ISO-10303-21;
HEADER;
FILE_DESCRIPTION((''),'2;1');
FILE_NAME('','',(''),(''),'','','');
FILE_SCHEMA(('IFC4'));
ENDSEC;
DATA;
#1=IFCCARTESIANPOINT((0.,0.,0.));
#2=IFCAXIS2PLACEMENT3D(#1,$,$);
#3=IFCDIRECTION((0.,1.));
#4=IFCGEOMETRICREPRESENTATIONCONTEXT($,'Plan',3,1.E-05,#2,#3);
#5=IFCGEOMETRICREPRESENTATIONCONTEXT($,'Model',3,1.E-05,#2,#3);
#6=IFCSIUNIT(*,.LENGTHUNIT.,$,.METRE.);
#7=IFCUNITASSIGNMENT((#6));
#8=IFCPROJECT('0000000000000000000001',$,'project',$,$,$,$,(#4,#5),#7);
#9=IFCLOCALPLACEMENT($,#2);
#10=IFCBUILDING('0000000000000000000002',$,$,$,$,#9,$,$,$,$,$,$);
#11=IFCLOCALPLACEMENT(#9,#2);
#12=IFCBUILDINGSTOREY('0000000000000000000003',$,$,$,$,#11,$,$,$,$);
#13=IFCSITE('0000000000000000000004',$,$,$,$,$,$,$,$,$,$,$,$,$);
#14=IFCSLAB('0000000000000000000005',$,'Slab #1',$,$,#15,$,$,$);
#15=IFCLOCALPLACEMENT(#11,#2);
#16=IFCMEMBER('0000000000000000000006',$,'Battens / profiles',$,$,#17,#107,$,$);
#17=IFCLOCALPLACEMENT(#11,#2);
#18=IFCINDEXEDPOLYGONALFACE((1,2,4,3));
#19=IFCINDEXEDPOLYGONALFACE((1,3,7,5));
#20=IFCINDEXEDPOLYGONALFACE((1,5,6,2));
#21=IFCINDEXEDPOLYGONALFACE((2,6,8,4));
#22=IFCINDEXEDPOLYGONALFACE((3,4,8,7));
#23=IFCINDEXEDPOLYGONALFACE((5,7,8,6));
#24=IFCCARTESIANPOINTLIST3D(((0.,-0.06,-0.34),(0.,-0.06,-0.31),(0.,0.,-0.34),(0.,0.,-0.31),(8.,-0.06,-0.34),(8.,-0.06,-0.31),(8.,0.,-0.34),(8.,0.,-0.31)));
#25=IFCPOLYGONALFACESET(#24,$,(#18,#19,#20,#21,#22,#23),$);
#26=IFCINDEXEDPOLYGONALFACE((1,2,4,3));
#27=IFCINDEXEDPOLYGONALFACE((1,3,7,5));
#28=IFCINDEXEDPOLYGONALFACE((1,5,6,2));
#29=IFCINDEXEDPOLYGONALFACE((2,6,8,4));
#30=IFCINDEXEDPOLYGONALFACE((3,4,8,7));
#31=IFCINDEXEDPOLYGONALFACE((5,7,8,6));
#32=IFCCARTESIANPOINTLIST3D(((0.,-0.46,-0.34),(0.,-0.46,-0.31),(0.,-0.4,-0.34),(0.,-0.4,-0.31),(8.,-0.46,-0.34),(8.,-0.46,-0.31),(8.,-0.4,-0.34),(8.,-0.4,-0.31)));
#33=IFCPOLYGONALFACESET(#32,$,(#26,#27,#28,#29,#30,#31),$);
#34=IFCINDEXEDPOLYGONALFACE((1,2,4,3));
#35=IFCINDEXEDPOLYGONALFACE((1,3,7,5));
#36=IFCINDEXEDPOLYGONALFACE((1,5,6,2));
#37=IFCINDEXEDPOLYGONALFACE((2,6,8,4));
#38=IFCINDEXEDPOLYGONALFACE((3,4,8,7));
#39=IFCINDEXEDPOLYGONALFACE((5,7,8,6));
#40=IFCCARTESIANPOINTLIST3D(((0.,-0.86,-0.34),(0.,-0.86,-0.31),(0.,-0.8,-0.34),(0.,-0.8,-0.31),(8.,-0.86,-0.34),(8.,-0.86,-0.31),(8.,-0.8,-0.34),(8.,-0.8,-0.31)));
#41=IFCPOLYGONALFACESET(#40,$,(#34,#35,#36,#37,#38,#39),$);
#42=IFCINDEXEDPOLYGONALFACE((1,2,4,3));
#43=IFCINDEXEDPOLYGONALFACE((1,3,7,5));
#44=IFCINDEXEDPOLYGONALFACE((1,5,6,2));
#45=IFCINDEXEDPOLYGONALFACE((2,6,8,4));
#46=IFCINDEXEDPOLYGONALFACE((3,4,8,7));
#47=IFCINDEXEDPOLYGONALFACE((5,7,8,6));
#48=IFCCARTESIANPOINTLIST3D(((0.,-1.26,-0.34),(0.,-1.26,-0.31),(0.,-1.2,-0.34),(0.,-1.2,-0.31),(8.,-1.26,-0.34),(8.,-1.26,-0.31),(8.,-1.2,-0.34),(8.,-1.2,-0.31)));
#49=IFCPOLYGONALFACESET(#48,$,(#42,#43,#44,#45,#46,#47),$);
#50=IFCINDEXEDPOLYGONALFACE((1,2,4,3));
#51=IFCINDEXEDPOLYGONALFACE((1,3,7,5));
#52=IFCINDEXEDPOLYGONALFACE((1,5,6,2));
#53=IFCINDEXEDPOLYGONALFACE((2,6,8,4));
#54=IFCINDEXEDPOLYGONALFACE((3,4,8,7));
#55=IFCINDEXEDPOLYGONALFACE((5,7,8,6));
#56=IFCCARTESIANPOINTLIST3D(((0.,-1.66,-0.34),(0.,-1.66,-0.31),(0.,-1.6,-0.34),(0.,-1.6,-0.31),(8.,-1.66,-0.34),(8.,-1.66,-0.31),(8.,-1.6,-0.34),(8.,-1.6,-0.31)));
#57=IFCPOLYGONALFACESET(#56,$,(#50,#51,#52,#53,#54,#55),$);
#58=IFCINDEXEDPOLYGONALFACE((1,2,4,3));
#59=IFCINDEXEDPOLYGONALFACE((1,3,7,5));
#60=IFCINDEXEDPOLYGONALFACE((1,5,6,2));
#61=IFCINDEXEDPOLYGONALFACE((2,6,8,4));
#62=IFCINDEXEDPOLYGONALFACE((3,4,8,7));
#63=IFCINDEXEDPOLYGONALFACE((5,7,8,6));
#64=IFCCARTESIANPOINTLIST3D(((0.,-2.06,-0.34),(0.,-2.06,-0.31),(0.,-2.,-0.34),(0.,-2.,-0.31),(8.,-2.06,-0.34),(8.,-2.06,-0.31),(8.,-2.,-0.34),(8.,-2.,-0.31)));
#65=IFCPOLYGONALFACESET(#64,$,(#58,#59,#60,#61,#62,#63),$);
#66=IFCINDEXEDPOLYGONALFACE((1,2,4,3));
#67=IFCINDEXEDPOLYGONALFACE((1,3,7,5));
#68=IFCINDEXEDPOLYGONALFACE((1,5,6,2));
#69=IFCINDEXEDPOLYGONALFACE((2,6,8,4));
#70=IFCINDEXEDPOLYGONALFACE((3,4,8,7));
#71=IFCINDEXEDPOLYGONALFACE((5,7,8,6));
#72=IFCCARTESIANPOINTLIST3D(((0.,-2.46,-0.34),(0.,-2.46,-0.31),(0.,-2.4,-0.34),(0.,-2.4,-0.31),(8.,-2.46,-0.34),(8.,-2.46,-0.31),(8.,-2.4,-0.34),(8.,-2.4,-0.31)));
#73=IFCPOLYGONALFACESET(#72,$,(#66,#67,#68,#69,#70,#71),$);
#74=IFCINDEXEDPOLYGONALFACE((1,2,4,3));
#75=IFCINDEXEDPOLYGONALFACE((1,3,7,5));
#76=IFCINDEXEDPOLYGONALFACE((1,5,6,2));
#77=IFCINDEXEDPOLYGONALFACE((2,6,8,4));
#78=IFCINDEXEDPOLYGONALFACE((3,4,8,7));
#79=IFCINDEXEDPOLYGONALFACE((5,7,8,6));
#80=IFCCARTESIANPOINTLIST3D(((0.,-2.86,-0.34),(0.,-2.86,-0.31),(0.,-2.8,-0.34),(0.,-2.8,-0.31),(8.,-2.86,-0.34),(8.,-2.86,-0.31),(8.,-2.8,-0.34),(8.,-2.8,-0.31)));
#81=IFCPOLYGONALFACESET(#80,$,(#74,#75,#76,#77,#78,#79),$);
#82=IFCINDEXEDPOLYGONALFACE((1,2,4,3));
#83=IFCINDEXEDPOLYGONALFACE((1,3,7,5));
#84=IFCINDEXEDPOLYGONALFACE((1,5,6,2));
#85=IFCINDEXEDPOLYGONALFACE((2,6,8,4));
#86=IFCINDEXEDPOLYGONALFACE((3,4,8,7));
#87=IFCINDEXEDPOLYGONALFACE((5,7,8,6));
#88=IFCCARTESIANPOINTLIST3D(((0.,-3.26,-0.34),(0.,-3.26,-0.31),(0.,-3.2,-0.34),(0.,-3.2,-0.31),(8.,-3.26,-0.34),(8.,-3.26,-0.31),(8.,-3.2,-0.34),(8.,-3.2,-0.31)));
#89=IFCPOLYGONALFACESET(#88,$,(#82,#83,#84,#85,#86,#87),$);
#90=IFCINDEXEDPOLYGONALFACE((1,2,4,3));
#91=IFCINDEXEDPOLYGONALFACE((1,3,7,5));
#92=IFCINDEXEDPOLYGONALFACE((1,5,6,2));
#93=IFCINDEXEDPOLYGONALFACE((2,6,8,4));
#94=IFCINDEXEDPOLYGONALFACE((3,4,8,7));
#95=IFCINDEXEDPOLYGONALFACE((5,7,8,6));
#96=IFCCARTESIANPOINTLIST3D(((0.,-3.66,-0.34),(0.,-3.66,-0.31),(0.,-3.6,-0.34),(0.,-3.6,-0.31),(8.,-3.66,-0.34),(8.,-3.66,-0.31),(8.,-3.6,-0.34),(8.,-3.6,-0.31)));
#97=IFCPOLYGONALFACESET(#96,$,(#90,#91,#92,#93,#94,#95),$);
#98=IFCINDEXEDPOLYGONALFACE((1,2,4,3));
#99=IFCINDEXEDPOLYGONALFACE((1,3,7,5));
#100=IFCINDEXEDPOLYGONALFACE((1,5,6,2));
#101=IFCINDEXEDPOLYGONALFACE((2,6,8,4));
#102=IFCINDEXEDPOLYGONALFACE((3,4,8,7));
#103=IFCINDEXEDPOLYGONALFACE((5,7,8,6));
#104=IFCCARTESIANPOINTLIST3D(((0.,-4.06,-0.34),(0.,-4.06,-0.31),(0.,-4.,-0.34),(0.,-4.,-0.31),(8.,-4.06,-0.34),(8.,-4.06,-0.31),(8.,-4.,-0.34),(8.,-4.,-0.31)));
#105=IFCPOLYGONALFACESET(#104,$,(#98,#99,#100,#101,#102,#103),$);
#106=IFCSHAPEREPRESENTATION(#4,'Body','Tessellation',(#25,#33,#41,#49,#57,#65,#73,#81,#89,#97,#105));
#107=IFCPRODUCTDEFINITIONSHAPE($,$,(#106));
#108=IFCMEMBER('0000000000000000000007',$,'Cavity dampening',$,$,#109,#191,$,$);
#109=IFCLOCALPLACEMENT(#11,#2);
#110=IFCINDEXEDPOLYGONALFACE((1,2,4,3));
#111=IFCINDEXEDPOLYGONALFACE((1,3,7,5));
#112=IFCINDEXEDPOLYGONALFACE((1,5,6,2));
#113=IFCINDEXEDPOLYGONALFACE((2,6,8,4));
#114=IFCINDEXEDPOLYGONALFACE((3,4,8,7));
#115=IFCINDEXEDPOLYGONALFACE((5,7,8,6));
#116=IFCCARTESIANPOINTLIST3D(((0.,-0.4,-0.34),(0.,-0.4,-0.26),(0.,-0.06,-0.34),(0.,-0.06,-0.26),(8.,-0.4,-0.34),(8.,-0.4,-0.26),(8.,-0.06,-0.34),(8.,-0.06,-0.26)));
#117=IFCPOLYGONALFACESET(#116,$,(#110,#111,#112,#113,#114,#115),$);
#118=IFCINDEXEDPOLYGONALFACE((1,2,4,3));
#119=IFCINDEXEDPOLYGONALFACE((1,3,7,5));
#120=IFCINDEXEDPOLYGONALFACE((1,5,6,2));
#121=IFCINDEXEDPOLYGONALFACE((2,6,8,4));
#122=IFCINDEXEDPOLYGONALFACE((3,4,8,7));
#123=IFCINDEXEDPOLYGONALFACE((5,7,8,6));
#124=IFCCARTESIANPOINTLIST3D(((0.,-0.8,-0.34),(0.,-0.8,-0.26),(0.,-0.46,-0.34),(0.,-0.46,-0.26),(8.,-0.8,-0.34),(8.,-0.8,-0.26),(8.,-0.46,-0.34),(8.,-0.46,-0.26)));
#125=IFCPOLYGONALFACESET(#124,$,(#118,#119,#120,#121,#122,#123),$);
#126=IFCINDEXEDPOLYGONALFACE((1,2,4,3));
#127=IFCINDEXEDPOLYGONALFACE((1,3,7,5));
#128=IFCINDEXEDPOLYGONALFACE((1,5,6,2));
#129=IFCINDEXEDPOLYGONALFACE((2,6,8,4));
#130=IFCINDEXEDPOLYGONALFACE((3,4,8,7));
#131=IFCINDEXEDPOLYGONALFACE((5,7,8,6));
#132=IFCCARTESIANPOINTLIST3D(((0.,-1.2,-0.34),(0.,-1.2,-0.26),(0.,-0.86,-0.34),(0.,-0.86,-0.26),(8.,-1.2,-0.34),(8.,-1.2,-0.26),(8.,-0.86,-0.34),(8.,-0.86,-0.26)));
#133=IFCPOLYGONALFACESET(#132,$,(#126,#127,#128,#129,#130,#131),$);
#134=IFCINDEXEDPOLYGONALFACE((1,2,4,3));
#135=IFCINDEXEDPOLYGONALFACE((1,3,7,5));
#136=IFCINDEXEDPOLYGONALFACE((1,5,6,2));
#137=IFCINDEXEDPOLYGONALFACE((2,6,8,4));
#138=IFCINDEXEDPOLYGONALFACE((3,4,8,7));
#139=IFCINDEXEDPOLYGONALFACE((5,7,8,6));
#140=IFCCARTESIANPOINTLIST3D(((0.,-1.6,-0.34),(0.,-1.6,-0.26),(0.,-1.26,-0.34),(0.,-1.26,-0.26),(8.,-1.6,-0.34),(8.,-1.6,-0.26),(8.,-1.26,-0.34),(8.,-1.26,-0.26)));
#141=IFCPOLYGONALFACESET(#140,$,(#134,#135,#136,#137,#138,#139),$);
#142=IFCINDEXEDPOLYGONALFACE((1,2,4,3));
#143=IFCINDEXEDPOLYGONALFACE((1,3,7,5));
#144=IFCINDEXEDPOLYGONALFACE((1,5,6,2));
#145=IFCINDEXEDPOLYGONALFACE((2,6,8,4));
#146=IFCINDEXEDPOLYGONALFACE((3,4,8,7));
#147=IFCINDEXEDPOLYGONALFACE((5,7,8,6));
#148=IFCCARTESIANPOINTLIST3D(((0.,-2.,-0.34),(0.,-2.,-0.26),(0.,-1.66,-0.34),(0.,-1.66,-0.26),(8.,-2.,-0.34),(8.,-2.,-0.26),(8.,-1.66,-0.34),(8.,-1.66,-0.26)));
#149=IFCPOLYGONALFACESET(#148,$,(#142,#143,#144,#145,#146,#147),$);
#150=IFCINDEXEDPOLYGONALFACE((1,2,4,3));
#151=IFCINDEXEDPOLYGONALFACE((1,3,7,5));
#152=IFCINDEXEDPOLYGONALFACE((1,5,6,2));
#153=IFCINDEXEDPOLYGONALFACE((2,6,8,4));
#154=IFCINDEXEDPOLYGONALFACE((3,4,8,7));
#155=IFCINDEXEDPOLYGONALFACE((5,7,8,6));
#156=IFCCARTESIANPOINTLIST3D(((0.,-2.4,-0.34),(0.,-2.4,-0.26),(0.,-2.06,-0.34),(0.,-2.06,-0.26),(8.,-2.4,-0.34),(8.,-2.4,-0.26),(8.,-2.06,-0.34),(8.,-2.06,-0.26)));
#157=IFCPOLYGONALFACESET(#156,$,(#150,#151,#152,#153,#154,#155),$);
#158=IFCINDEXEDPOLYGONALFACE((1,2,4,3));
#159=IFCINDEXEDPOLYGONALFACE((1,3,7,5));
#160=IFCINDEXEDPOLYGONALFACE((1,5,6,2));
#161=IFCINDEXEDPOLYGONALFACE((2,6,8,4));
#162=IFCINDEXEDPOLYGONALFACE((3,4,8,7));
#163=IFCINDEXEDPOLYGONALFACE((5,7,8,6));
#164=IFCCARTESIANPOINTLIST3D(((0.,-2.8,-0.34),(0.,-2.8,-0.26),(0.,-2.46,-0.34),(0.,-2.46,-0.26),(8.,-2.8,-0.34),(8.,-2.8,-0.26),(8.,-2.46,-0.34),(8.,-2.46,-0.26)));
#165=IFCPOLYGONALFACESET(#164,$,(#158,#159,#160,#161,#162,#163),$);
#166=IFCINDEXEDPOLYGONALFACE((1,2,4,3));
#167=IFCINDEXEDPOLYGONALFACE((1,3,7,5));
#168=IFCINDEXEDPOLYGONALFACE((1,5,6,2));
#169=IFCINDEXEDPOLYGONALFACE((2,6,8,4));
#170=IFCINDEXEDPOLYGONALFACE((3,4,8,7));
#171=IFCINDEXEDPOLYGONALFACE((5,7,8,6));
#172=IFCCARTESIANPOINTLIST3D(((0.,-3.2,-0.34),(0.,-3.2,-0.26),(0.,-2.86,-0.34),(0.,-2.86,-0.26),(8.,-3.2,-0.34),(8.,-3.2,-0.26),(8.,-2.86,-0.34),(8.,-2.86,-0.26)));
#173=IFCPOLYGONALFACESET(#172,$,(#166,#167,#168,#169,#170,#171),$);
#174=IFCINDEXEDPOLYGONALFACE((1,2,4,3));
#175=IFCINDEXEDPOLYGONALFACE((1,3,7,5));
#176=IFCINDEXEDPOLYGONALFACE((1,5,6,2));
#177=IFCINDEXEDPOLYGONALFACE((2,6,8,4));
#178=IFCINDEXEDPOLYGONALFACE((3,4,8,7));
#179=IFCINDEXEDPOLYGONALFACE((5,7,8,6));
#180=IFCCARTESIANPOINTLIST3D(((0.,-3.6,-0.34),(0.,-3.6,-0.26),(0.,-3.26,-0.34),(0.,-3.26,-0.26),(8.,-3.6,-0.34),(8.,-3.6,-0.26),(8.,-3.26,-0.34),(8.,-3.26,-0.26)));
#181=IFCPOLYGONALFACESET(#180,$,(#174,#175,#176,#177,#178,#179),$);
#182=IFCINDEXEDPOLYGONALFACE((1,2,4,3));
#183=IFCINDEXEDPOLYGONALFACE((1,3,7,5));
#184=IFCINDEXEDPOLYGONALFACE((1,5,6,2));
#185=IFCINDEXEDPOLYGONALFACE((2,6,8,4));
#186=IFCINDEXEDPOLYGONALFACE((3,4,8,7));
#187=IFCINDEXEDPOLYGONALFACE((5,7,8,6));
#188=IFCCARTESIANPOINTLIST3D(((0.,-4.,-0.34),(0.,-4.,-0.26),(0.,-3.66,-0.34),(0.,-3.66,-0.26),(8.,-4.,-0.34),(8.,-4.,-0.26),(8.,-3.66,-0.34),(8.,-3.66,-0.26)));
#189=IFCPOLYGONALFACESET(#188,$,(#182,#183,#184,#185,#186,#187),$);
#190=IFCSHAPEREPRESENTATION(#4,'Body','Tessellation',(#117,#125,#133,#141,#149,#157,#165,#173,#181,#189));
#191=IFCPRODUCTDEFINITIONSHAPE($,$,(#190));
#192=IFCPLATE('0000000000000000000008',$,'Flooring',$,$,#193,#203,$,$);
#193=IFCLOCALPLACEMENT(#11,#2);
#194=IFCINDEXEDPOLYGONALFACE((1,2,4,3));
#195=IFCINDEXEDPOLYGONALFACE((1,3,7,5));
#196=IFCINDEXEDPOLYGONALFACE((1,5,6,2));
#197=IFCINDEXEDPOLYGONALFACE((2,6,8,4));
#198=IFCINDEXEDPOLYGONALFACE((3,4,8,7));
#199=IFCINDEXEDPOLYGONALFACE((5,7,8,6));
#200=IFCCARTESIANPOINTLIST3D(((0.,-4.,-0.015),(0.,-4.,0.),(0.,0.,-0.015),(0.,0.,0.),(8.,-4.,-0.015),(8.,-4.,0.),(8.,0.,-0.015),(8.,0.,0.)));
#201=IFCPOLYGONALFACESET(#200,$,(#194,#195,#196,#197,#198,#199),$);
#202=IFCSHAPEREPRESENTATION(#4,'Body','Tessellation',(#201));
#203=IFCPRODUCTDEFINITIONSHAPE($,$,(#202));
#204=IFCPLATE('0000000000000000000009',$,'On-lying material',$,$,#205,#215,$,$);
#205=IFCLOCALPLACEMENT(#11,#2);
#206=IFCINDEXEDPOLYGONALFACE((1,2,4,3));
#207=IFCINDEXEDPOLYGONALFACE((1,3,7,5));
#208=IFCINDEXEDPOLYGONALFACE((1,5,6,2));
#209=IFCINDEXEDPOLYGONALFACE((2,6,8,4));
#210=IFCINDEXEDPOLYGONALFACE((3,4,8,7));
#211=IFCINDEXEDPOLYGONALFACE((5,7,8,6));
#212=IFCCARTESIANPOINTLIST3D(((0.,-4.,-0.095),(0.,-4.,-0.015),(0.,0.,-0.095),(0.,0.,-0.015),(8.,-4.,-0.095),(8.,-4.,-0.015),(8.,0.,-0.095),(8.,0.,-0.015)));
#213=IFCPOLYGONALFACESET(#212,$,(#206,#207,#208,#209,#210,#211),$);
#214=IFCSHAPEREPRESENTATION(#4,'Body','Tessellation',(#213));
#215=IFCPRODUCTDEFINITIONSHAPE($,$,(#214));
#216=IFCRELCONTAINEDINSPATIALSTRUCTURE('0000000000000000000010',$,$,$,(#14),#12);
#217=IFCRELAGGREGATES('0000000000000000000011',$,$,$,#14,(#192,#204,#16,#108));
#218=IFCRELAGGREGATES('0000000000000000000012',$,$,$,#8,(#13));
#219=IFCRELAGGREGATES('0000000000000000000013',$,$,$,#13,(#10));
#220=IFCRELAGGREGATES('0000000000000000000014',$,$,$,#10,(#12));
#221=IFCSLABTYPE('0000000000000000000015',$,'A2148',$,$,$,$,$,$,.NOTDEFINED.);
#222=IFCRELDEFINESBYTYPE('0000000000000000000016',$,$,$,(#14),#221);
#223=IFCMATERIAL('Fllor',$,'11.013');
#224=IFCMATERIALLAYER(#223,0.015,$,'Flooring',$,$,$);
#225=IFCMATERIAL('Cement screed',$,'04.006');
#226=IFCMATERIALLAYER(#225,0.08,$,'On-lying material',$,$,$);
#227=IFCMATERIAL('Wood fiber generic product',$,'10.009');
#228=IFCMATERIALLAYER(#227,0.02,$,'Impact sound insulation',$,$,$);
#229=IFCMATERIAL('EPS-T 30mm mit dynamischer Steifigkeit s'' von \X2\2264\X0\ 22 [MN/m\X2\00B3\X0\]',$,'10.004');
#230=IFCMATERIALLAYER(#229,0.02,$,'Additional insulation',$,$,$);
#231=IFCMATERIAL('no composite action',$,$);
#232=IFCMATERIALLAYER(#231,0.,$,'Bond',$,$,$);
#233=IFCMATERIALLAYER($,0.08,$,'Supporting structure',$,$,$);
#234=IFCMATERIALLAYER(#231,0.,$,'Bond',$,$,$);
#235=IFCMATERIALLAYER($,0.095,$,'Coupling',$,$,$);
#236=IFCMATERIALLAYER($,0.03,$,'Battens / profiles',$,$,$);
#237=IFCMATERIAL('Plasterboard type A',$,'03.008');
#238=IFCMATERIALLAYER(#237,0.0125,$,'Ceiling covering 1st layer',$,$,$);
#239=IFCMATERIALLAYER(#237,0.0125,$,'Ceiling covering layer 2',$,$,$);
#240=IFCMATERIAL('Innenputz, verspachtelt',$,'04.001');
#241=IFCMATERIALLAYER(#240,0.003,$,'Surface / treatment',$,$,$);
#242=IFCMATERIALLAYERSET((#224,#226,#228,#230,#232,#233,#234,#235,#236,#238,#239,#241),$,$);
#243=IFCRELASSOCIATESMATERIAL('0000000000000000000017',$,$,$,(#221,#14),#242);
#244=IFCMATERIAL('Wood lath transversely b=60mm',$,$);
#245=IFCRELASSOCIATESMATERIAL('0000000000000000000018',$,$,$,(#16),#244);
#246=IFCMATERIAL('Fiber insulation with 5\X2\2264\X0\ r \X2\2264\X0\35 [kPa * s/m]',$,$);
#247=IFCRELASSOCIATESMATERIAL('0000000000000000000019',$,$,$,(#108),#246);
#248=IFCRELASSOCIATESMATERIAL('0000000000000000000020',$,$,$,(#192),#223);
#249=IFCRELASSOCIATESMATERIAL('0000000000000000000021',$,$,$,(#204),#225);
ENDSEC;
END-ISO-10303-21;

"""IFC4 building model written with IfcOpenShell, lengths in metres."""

from ifc_helpers import new_model, si_unit, direction, frame, frame_2d, origin, origin_with_axes, place, context, project, spatial, rectangle, extrude, material, layer, layer_set, type_object, element, aggregate, save


model = new_model("IFC4")

# Units and contexts
plan_context = context("Plan", 3, precision=1e-05, world=origin(), true_north=direction((0.0, 1.0)))
model_context = context("Model", 3, precision=1e-05, world=origin(), true_north=direction((0.0, 1.0)))
ifc_project = project(units=[si_unit("LENGTHUNIT", "METRE")], contexts=[plan_context, model_context])

# Site, building, storey
site = spatial("IfcSite", under=ifc_project)
building_placement = place(None, origin())
building = spatial("IfcBuilding", under=site, at=building_placement)
storey_placement = place(building_placement, origin())
storey = spatial("IfcBuildingStorey", under=building, at=storey_placement)

# Slab, members, plates
ifc_material_1 = material(Name="Fllor", Category="11.013")
ifc_layer_1 = layer(ifc_material_1, 0.015, Name="Flooring")
ifc_material_2 = material(Name="Cement screed", Category="04.006")
ifc_layer_2 = layer(ifc_material_2, 0.08, Name="On-lying material")
ifc_material_3 = material(Name="Wood fiber generic product", Category="10.009")
ifc_layer_3 = layer(ifc_material_3, 0.02, Name="Impact sound insulation")
ifc_material_4 = material(Name="EPS-T 30mm mit dynamischer Steifigkeit s' von ≤ 22 [MN/m³]", Category="10.004")
ifc_layer_4 = layer(ifc_material_4, 0.02, Name="Additional insulation")
ifc_material_5 = material(Name="no composite action")
ifc_layer_5 = layer(ifc_material_5, 0.0, Name="Bond")
ifc_layer_6 = layer(None, 0.08, Name="Supporting structure")
ifc_layer_7 = layer(ifc_material_5, 0.0, Name="Bond")
ifc_layer_8 = layer(None, 0.095, Name="Coupling")
ifc_layer_9 = layer(None, 0.03, Name="Battens / profiles")
ifc_material_6 = material(Name="Plasterboard type A", Category="03.008")
ifc_layer_10 = layer(ifc_material_6, 0.0125, Name="Ceiling covering 1st layer")
ifc_layer_11 = layer(ifc_material_6, 0.0125, Name="Ceiling covering layer 2")
ifc_material_7 = material(Name="Innenputz, verspachtelt", Category="04.001")
ifc_layer_12 = layer(ifc_material_7, 0.003, Name="Surface / treatment")
ifc_layer_set = layer_set([ifc_layer_1, ifc_layer_2, ifc_layer_3, ifc_layer_4, ifc_layer_5, ifc_layer_6, ifc_layer_7, ifc_layer_8, ifc_layer_9, ifc_layer_10, ifc_layer_11, ifc_layer_12])
slab_type = type_object("IfcSlabType", Name="A2148", PredefinedType="NOTDEFINED", material=ifc_layer_set)
slab_placement = place(None, frame((0.0, 0.0, 0.0), z_axis=(0.0, 0.0, -1.0), x_axis=(1.0, 0.0, 0.0)))
slab = element("IfcSlab", 1, at=slab_placement, inside=storey, type_object=slab_type, material=ifc_layer_set, Name="Slab #1")
ifc_material_8 = material(Name="Wood lath transversely b=60mm")
member_1_placement = place(slab_placement, origin())
member_1 = element("IfcMember", 2, at=member_1_placement, material=ifc_material_8, Name="Battens / profiles", context=plan_context, shape_type="SweptSolid", body=[
    extrude(rectangle(XDim=0.06, YDim=0.03, at=frame_2d((0.03, 0.015), x_axis=(1.0, 0.0))), frame((0.0, 0.0, 0.31), z_axis=(1.0, 0.0, 0.0), x_axis=(0.0, 1.0, 0.0)), (0.0, 0.0, 1.0), 8.0),
    extrude(rectangle(XDim=0.06, YDim=0.03, at=frame_2d((0.03, 0.015), x_axis=(1.0, 0.0))), frame((0.0, 0.4, 0.31), z_axis=(1.0, 0.0, 0.0), x_axis=(0.0, 1.0, 0.0)), (0.0, 0.0, 1.0), 8.0),
    extrude(rectangle(XDim=0.06, YDim=0.03, at=frame_2d((0.03, 0.015), x_axis=(1.0, 0.0))), frame((0.0, 0.8, 0.31), z_axis=(1.0, 0.0, 0.0), x_axis=(0.0, 1.0, 0.0)), (0.0, 0.0, 1.0), 8.0),
    extrude(rectangle(XDim=0.06, YDim=0.03, at=frame_2d((0.03, 0.015), x_axis=(1.0, 0.0))), frame((0.0, 1.2, 0.31), z_axis=(1.0, 0.0, 0.0), x_axis=(0.0, 1.0, 0.0)), (0.0, 0.0, 1.0), 8.0),
    extrude(rectangle(XDim=0.06, YDim=0.03, at=frame_2d((0.03, 0.015), x_axis=(1.0, 0.0))), frame((0.0, 1.6, 0.31), z_axis=(1.0, 0.0, 0.0), x_axis=(0.0, 1.0, 0.0)), (0.0, 0.0, 1.0), 8.0),
    extrude(rectangle(XDim=0.06, YDim=0.03, at=frame_2d((0.03, 0.015), x_axis=(1.0, 0.0))), frame((0.0, 2.0, 0.31), z_axis=(1.0, 0.0, 0.0), x_axis=(0.0, 1.0, 0.0)), (0.0, 0.0, 1.0), 8.0),
    extrude(rectangle(XDim=0.06, YDim=0.03, at=frame_2d((0.03, 0.015), x_axis=(1.0, 0.0))), frame((0.0, 2.4, 0.31), z_axis=(1.0, 0.0, 0.0), x_axis=(0.0, 1.0, 0.0)), (0.0, 0.0, 1.0), 8.0),
    extrude(rectangle(XDim=0.06, YDim=0.03, at=frame_2d((0.03, 0.015), x_axis=(1.0, 0.0))), frame((0.0, 2.8, 0.31), z_axis=(1.0, 0.0, 0.0), x_axis=(0.0, 1.0, 0.0)), (0.0, 0.0, 1.0), 8.0),
    extrude(rectangle(XDim=0.06, YDim=0.03, at=frame_2d((0.03, 0.015), x_axis=(1.0, 0.0))), frame((0.0, 3.2, 0.31), z_axis=(1.0, 0.0, 0.0), x_axis=(0.0, 1.0, 0.0)), (0.0, 0.0, 1.0), 8.0),
    extrude(rectangle(XDim=0.06, YDim=0.03, at=frame_2d((0.03, 0.015), x_axis=(1.0, 0.0))), frame((0.0, 3.6, 0.31), z_axis=(1.0, 0.0, 0.0), x_axis=(0.0, 1.0, 0.0)), (0.0, 0.0, 1.0), 8.0),
    extrude(rectangle(XDim=0.06, YDim=0.03, at=frame_2d((0.03, 0.015), x_axis=(1.0, 0.0))), frame((0.0, 4.0, 0.31), z_axis=(1.0, 0.0, 0.0), x_axis=(0.0, 1.0, 0.0)), (0.0, 0.0, 1.0), 8.0),
])
ifc_material_9 = material(Name="Fiber insulation with 5≤ r ≤35 [kPa * s/m]")
member_2_placement = place(slab_placement, origin())
member_2 = element("IfcMember", 3, at=member_2_placement, material=ifc_material_9, Name="Cavity dampening", context=plan_context, shape_type="SweptSolid", body=[
    extrude(rectangle(XDim=0.34, YDim=0.08, at=frame_2d((0.17, 0.04), x_axis=(1.0, 0.0))), frame((0.0, 0.06, 0.26), z_axis=(1.0, 0.0, 0.0), x_axis=(0.0, 1.0, 0.0)), (0.0, 0.0, 1.0), 8.0),
    extrude(rectangle(XDim=0.34, YDim=0.08, at=frame_2d((0.17, 0.04), x_axis=(1.0, 0.0))), frame((0.0, 0.46, 0.26), z_axis=(1.0, 0.0, 0.0), x_axis=(0.0, 1.0, 0.0)), (0.0, 0.0, 1.0), 8.0),
    extrude(rectangle(XDim=0.34, YDim=0.08, at=frame_2d((0.17, 0.04), x_axis=(1.0, 0.0))), frame((0.0, 0.86, 0.26), z_axis=(1.0, 0.0, 0.0), x_axis=(0.0, 1.0, 0.0)), (0.0, 0.0, 1.0), 8.0),
    extrude(rectangle(XDim=0.34, YDim=0.08, at=frame_2d((0.17, 0.04), x_axis=(1.0, 0.0))), frame((0.0, 1.26, 0.26), z_axis=(1.0, 0.0, 0.0), x_axis=(0.0, 1.0, 0.0)), (0.0, 0.0, 1.0), 8.0),
    extrude(rectangle(XDim=0.34, YDim=0.08, at=frame_2d((0.17, 0.04), x_axis=(1.0, 0.0))), frame((0.0, 1.66, 0.26), z_axis=(1.0, 0.0, 0.0), x_axis=(0.0, 1.0, 0.0)), (0.0, 0.0, 1.0), 8.0),
    extrude(rectangle(XDim=0.34, YDim=0.08, at=frame_2d((0.17, 0.04), x_axis=(1.0, 0.0))), frame((0.0, 2.06, 0.26), z_axis=(1.0, 0.0, 0.0), x_axis=(0.0, 1.0, 0.0)), (0.0, 0.0, 1.0), 8.0),
    extrude(rectangle(XDim=0.34, YDim=0.08, at=frame_2d((0.17, 0.04), x_axis=(1.0, 0.0))), frame((0.0, 2.46, 0.26), z_axis=(1.0, 0.0, 0.0), x_axis=(0.0, 1.0, 0.0)), (0.0, 0.0, 1.0), 8.0),
    extrude(rectangle(XDim=0.34, YDim=0.08, at=frame_2d((0.17, 0.04), x_axis=(1.0, 0.0))), frame((0.0, 2.86, 0.26), z_axis=(1.0, 0.0, 0.0), x_axis=(0.0, 1.0, 0.0)), (0.0, 0.0, 1.0), 8.0),
    extrude(rectangle(XDim=0.34, YDim=0.08, at=frame_2d((0.17, 0.04), x_axis=(1.0, 0.0))), frame((0.0, 3.26, 0.26), z_axis=(1.0, 0.0, 0.0), x_axis=(0.0, 1.0, 0.0)), (0.0, 0.0, 1.0), 8.0),
    extrude(rectangle(XDim=0.34, YDim=0.08, at=frame_2d((0.17, 0.04), x_axis=(1.0, 0.0))), frame((0.0, 3.66, 0.26), z_axis=(1.0, 0.0, 0.0), x_axis=(0.0, 1.0, 0.0)), (0.0, 0.0, 1.0), 8.0),
])
plate_1_placement = place(slab_placement, origin())
plate_1 = element("IfcPlate", 4, at=plate_1_placement, material=ifc_material_1, Name="Flooring", context=plan_context, shape_type="SweptSolid", body=[
    extrude(rectangle(XDim=8.0, YDim=4.0, at=frame_2d((4.0, 2.0), x_axis=(1.0, 0.0))), origin_with_axes(), (0.0, 0.0, 1.0), 0.015),
])
plate_2_placement = place(slab_placement, origin())
plate_2 = element("IfcPlate", 5, at=plate_2_placement, material=ifc_material_2, Name="On-lying material", context=plan_context, shape_type="SweptSolid", body=[
    extrude(rectangle(XDim=8.0, YDim=4.0, at=frame_2d((4.0, 2.0), x_axis=(1.0, 0.0))), frame((0.0, 0.0, 0.015), z_axis=(0.0, 0.0, 1.0), x_axis=(1.0, 0.0, 0.0)), (0.0, 0.0, 1.0), 0.08),
])
aggregate(slab, [plate_1, plate_2, member_1, member_2])

save(model, "model.ifc")
